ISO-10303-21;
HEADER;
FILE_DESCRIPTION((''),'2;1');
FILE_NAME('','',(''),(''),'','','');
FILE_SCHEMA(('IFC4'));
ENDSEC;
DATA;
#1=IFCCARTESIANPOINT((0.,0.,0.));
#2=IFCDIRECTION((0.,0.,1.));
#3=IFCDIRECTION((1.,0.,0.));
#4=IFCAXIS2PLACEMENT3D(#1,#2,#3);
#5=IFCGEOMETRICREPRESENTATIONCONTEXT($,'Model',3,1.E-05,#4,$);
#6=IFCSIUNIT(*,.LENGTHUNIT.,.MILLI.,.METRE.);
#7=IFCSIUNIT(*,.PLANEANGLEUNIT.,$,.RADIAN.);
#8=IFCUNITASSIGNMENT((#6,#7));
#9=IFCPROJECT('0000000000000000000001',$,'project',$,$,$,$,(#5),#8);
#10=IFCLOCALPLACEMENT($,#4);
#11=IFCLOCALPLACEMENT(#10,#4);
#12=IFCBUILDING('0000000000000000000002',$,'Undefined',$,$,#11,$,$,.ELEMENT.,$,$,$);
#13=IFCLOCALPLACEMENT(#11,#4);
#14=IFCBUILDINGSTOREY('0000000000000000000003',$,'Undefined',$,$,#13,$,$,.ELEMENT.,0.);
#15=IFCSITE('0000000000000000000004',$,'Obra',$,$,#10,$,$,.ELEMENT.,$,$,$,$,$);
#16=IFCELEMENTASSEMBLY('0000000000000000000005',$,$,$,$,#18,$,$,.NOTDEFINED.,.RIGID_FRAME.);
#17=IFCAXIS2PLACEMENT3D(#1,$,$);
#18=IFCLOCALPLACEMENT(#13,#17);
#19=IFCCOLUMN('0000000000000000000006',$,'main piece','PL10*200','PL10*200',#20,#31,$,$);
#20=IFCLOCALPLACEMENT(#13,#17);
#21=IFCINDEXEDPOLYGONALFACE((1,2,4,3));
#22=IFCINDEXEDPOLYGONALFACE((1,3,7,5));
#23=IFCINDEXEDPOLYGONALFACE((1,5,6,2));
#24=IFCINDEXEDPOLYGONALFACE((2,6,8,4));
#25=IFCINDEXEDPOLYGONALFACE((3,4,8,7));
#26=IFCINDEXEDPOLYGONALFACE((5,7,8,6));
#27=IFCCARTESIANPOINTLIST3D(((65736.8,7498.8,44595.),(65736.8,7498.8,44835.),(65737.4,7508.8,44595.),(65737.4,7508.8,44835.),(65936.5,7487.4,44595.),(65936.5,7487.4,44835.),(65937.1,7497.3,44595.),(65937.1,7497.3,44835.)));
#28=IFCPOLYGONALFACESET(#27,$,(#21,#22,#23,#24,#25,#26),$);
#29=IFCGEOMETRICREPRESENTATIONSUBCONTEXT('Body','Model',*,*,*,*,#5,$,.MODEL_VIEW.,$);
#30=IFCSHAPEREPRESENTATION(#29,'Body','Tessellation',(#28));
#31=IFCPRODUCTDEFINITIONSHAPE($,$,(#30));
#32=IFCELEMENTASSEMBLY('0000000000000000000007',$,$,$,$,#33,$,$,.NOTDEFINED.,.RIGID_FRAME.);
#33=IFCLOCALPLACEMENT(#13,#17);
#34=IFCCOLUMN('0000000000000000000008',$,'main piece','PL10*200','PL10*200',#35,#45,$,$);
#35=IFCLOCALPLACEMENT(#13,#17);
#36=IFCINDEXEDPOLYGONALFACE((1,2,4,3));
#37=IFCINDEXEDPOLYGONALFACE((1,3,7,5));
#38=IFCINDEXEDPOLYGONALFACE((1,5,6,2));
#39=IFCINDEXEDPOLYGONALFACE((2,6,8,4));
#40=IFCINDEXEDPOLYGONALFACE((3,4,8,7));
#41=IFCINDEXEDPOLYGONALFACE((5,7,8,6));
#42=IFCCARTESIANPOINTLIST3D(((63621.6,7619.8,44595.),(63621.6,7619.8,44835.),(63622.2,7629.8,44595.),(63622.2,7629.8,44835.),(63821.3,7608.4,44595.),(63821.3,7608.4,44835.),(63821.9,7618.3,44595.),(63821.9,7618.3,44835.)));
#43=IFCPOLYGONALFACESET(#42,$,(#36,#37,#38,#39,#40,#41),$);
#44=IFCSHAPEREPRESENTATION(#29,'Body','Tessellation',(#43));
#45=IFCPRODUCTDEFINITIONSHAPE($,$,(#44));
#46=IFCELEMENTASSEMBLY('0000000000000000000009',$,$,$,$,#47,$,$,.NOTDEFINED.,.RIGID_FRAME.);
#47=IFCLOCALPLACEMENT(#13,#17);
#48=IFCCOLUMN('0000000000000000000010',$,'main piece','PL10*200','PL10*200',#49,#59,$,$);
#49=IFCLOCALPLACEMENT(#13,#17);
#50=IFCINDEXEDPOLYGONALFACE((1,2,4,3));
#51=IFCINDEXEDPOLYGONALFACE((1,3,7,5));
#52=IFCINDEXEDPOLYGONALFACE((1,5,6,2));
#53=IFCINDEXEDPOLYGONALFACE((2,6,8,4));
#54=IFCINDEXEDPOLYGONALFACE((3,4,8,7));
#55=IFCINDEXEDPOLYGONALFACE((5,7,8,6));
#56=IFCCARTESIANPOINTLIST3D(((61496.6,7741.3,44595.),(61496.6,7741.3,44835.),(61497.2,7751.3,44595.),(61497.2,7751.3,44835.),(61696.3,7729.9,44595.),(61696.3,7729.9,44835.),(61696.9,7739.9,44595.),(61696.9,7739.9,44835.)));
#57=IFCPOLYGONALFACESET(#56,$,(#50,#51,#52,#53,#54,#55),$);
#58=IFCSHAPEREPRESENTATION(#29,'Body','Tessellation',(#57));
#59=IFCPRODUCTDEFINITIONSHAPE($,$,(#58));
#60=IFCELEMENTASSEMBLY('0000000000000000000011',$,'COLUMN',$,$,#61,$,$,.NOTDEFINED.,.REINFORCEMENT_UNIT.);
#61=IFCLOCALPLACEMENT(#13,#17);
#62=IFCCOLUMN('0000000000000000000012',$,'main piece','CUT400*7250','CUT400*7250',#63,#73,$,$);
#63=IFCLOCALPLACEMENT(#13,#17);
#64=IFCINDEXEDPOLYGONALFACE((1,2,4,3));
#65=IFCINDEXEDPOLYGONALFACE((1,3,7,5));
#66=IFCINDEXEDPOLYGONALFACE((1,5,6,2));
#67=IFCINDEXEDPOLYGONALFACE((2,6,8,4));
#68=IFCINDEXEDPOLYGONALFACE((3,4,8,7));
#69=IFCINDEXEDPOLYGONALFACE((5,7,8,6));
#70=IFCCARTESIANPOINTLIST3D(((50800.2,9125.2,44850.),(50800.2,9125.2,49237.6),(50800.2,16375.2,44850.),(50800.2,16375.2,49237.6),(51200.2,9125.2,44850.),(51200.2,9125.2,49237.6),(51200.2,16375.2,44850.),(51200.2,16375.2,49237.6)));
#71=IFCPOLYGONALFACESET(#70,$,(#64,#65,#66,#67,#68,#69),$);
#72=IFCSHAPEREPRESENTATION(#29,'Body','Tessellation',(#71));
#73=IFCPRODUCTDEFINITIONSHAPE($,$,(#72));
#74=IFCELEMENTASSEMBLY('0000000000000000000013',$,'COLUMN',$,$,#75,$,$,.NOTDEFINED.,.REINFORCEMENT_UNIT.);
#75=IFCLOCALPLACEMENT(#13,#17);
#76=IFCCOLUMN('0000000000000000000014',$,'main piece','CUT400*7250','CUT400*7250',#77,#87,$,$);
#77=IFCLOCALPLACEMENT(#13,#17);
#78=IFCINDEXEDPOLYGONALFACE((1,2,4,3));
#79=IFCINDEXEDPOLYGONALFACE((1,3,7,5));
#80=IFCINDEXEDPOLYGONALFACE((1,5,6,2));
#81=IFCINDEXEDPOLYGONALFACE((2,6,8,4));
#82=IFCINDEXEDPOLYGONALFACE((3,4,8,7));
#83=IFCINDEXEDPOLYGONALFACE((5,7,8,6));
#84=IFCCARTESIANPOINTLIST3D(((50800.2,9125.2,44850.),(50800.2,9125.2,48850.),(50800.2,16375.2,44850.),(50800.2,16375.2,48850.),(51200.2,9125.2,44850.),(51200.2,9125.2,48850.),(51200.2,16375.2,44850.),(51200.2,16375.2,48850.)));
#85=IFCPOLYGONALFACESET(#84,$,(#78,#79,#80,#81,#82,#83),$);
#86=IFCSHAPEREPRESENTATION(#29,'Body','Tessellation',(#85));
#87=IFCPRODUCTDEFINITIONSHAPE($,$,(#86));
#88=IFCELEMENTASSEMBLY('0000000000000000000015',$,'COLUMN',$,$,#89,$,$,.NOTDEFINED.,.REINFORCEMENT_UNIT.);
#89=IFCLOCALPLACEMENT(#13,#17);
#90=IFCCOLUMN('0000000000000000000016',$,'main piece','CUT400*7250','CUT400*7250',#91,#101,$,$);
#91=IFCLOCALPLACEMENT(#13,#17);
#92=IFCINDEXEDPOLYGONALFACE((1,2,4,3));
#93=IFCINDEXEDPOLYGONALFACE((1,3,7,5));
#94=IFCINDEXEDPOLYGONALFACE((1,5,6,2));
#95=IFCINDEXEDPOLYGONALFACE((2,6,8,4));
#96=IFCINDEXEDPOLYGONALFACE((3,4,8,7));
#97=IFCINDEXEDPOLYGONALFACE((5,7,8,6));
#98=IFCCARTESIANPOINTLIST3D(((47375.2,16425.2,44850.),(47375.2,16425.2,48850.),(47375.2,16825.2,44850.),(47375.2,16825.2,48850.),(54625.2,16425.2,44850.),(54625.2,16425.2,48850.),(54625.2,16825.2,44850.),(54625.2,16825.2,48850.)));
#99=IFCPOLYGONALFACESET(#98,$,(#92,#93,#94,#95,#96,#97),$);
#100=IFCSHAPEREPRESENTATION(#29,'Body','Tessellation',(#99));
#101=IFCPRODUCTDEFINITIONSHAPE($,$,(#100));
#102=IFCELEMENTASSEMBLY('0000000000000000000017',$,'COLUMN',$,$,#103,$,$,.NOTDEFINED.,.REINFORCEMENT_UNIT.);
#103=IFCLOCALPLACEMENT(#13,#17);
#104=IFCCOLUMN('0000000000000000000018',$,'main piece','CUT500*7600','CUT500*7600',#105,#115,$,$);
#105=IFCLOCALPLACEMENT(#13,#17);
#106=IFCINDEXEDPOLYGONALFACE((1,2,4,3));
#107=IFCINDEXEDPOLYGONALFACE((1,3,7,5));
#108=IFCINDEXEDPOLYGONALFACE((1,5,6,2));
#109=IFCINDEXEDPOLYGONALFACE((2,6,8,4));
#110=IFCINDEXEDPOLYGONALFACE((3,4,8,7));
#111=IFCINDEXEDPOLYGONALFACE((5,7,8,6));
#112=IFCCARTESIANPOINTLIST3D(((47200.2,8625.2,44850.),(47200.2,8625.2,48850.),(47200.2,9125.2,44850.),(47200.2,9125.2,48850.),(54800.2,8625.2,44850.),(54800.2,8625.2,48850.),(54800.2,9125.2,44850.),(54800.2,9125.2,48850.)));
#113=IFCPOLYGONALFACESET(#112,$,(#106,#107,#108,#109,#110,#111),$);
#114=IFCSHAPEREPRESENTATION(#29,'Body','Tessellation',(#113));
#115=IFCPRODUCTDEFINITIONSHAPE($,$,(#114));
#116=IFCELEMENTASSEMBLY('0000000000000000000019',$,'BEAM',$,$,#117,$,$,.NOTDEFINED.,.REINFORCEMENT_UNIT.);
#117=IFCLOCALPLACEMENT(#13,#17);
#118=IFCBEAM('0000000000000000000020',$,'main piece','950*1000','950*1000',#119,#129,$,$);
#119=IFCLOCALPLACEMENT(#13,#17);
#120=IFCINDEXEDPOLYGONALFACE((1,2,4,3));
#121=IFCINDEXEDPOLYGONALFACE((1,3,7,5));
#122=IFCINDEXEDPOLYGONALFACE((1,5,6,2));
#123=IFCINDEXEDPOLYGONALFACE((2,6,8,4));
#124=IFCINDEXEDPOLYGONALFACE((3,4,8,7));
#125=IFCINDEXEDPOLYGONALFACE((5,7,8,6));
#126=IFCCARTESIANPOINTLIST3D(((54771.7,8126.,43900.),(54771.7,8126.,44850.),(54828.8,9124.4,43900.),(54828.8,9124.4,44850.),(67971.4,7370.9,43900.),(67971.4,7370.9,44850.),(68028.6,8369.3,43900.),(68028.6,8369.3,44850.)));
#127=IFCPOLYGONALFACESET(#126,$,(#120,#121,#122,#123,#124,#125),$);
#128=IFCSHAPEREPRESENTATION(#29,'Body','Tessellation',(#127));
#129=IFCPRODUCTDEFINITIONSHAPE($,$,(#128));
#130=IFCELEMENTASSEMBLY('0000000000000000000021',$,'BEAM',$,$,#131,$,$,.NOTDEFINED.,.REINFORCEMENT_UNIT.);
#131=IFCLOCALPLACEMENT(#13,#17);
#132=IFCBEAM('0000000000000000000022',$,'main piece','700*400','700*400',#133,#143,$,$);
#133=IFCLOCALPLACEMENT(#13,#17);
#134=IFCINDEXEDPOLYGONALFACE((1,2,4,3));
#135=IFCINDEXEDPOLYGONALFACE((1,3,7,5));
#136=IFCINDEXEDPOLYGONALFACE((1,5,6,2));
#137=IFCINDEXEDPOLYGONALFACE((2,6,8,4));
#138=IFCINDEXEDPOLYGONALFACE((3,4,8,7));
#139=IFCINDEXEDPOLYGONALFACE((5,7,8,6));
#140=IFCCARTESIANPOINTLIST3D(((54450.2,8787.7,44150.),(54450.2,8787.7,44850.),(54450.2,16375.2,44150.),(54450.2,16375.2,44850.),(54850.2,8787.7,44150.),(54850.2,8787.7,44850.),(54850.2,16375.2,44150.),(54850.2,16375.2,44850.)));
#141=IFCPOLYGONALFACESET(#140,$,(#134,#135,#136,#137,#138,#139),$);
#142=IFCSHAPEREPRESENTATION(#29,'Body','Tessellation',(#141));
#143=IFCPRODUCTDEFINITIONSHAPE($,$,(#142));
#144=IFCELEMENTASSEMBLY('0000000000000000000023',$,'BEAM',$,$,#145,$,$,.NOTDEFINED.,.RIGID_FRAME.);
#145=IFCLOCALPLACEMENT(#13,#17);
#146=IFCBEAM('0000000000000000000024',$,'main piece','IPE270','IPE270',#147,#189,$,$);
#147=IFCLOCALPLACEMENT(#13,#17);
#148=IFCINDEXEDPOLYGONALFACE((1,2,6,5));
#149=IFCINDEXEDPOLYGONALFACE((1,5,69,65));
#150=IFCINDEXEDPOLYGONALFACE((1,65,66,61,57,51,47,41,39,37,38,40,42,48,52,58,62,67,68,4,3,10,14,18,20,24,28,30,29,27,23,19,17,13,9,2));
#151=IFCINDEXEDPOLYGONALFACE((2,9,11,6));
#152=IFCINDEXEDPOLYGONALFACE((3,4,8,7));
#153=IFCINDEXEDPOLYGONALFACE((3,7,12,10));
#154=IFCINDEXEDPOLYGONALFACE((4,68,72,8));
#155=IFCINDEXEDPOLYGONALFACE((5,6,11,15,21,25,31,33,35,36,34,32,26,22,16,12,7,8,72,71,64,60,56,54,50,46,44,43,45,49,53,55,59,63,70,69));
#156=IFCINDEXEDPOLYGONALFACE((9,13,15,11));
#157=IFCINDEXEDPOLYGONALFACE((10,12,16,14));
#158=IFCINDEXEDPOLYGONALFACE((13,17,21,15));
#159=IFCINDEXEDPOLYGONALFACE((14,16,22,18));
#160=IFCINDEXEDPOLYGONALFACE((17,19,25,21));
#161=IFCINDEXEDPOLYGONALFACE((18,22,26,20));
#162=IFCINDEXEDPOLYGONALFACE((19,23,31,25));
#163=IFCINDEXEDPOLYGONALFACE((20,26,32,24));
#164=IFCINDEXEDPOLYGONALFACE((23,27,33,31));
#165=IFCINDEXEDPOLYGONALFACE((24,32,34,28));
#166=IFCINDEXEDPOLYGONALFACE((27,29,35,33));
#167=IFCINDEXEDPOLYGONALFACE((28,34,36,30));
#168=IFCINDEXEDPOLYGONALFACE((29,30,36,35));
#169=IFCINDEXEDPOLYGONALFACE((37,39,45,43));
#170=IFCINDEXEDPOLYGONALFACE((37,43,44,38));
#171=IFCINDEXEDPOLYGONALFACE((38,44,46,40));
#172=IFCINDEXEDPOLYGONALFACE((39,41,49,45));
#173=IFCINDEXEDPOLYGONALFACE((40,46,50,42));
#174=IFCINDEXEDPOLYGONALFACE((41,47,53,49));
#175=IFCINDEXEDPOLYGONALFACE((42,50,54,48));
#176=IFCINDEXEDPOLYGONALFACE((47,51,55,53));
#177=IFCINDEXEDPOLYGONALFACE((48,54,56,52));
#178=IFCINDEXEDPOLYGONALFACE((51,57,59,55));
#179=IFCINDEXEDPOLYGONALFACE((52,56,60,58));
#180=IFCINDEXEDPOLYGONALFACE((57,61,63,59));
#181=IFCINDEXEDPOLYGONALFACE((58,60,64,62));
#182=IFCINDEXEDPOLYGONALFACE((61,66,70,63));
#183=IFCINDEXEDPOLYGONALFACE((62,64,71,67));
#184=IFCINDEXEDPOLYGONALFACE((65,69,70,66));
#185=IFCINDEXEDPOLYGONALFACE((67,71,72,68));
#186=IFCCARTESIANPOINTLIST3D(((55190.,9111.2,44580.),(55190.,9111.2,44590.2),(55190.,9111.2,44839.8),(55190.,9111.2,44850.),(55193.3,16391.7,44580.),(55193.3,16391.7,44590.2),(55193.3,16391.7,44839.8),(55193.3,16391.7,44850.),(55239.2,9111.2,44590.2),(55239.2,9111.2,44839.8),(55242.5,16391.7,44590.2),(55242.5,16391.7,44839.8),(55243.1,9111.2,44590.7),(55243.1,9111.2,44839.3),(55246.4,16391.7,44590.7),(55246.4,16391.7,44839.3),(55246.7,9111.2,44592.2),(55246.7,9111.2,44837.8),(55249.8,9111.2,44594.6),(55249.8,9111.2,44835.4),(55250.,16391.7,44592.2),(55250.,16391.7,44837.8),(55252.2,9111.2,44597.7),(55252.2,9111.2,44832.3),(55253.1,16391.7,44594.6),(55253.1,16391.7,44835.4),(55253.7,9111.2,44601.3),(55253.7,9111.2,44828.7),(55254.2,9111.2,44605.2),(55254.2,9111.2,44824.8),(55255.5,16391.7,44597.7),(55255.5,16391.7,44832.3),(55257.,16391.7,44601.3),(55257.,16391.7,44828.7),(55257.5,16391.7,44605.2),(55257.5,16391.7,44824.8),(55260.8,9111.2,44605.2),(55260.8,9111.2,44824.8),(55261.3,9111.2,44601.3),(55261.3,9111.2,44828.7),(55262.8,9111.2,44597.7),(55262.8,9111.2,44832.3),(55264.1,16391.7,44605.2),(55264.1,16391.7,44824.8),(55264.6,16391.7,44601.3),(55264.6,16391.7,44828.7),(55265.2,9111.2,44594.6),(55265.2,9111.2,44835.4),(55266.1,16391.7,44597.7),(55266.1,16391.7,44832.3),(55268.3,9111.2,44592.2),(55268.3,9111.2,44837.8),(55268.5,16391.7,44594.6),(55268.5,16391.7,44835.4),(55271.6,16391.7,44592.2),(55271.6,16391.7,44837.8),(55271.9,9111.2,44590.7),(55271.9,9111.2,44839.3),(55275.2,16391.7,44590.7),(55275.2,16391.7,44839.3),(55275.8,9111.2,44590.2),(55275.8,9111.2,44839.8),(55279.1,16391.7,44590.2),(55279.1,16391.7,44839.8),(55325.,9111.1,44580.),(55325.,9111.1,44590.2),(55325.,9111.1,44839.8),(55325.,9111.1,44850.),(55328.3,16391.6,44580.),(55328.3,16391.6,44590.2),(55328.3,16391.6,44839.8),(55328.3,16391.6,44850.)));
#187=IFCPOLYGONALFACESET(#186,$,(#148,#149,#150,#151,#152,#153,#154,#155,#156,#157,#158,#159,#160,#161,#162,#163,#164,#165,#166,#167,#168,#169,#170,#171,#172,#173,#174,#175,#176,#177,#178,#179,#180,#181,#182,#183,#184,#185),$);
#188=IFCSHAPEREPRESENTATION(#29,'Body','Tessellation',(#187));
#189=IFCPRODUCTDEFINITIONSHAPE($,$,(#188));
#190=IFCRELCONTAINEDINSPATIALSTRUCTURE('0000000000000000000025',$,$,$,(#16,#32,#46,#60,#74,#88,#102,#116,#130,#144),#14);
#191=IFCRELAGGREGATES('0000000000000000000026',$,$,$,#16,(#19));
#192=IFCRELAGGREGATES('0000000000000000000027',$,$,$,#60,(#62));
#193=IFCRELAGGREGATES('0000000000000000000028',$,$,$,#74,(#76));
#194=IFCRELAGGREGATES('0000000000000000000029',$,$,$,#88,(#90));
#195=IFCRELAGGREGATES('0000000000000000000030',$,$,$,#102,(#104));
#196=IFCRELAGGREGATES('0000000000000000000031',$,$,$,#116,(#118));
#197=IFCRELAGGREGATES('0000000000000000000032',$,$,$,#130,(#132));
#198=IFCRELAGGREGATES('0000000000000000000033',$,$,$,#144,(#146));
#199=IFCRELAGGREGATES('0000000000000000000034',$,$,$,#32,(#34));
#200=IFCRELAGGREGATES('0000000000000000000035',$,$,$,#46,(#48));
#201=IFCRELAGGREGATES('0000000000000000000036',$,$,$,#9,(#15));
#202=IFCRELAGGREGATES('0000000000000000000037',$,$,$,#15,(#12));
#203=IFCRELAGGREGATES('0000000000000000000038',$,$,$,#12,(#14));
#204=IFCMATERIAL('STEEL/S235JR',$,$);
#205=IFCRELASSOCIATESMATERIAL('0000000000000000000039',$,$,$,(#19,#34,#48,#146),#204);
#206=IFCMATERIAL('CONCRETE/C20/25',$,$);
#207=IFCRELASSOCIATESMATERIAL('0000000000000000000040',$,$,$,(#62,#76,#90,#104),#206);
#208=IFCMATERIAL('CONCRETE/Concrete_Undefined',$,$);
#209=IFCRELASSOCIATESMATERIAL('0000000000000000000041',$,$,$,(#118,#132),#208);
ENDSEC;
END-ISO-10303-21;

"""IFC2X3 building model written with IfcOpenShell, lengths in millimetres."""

from ifc_helpers import new_model, si_unit, frame, origin_with_axes, origin_2d_with_axis, place, context, subcontext, project, spatial, rectangle, i_section, extrude, material, element, aggregate, save


model = new_model("IFC2X3")

# Units and contexts
model_context = context("Model", 3, precision=1e-05, world=origin_with_axes())
body_context = subcontext(model_context, "Body", "Model", "MODEL_VIEW")
ifc_project = project(units=[si_unit("LENGTHUNIT", "METRE", prefix="MILLI"), si_unit("PLANEANGLEUNIT", "RADIAN")], contexts=[model_context])

# Site, building, storey
site_placement = place(None, origin_with_axes())
site = spatial("IfcSite", under=ifc_project, at=site_placement, Name="Obra", CompositionType="ELEMENT")
building_placement = place(site_placement, origin_with_axes())
building = spatial("IfcBuilding", under=site, at=building_placement, Name="Undefined", CompositionType="ELEMENT")
storey_placement = place(building_placement, origin_with_axes())
storey = spatial("IfcBuildingStorey", under=building, at=storey_placement, Name="Undefined", CompositionType="ELEMENT", Elevation=0.0)

# Element assemblies, columns
assembly_1_placement = place(storey_placement, origin_with_axes())
assembly_1 = element("IfcElementAssembly", 1, at=assembly_1_placement, inside=storey, AssemblyPlace="NOTDEFINED", PredefinedType="RIGID_FRAME")
ifc_material_1 = material(Name="STEEL/S235JR")
column_1_placement = place(assembly_1_placement, frame((65836.9, 7498.1, 44595.0), z_axis=(0.0, 0.0, 1.0), x_axis=(-0.998368, 0.05711, 0.0)))
column_1 = element("IfcColumn", 2, at=column_1_placement, material=ifc_material_1, Name="main piece", Description="PL10*200", ObjectType="PL10*200", context=body_context, shape_type="SweptSolid", body=[
    extrude(rectangle(XDim=10.0, YDim=200.0, at=origin_2d_with_axis()), frame((0.0, 0.0, 240.0), z_axis=(0.0, 0.0, -1.0), x_axis=(0.0, 1.0, 0.0)), (0.0, 0.0, 1.0), 240.0),
])
aggregate(assembly_1, [column_1])
assembly_2_placement = place(storey_placement, origin_with_axes())
assembly_2 = element("IfcElementAssembly", 3, at=assembly_2_placement, inside=storey, AssemblyPlace="NOTDEFINED", PredefinedType="RIGID_FRAME")
column_2_placement = place(assembly_2_placement, frame((63721.7, 7619.1, 44595.0), z_axis=(0.0, 0.0, 1.0), x_axis=(-0.998368, 0.05711, 0.0)))
column_2 = element("IfcColumn", 4, at=column_2_placement, material=ifc_material_1, Name="main piece", Description="PL10*200", ObjectType="PL10*200", context=body_context, shape_type="SweptSolid", body=[
    extrude(rectangle(XDim=10.0, YDim=200.0, at=origin_2d_with_axis()), frame((0.0, 0.0, 240.0), z_axis=(0.0, 0.0, -1.0), x_axis=(0.0, 1.0, 0.0)), (0.0, 0.0, 1.0), 240.0),
])
assembly_3_placement = place(storey_placement, origin_with_axes())
assembly_3 = element("IfcElementAssembly", 5, at=assembly_3_placement, inside=storey, AssemblyPlace="NOTDEFINED", PredefinedType="RIGID_FRAME")
column_3_placement = place(assembly_3_placement, frame((61596.7, 7740.6, 44595.0), z_axis=(0.0, 0.0, 1.0), x_axis=(-0.998368, 0.05711, 0.0)))
column_3 = element("IfcColumn", 6, at=column_3_placement, material=ifc_material_1, Name="main piece", Description="PL10*200", ObjectType="PL10*200", context=body_context, shape_type="SweptSolid", body=[
    extrude(rectangle(XDim=10.0, YDim=200.0, at=origin_2d_with_axis()), frame((0.0, 0.0, 240.0), z_axis=(0.0, 0.0, -1.0), x_axis=(0.0, 1.0, 0.0)), (0.0, 0.0, 1.0), 240.0),
])
assembly_4_placement = place(storey_placement, origin_with_axes())
assembly_4 = element("IfcElementAssembly", 7, at=assembly_4_placement, inside=storey, Name="COLUMN", AssemblyPlace="NOTDEFINED", PredefinedType="REINFORCEMENT_UNIT")
ifc_material_2 = material(Name="CONCRETE/C20/25")
column_4_placement = place(assembly_4_placement, frame((51000.2, 12750.2, 44850.0), z_axis=(0.0, 0.0, 1.0), x_axis=(0.0, -1.0, 0.0)))
column_4 = element("IfcColumn", 8, at=column_4_placement, material=ifc_material_2, Name="main piece", Description="CUT400*7250", ObjectType="CUT400*7250", context=body_context, shape_type="SweptSolid", body=[
    extrude(rectangle(XDim=400.0, YDim=7250.0, at=origin_2d_with_axis()), frame((0.0, 0.0, 4387.6), z_axis=(0.0, 0.0, -1.0), x_axis=(0.0, 1.0, 0.0)), (0.0, 0.0, 1.0), 4387.6),
])
aggregate(assembly_4, [column_4])
assembly_5_placement = place(storey_placement, origin_with_axes())
assembly_5 = element("IfcElementAssembly", 9, at=assembly_5_placement, inside=storey, Name="COLUMN", AssemblyPlace="NOTDEFINED", PredefinedType="REINFORCEMENT_UNIT")
column_5_placement = place(assembly_5_placement, frame((51000.2, 12750.2, 44850.0), z_axis=(0.0, 0.0, 1.0), x_axis=(0.0, -1.0, 0.0)))
column_5 = element("IfcColumn", 10, at=column_5_placement, material=ifc_material_2, Name="main piece", Description="CUT400*7250", ObjectType="CUT400*7250", context=body_context, shape_type="SweptSolid", body=[
    extrude(rectangle(XDim=400.0, YDim=7250.0, at=origin_2d_with_axis()), frame((0.0, 0.0, 4000.0), z_axis=(0.0, 0.0, -1.0), x_axis=(0.0, 1.0, 0.0)), (0.0, 0.0, 1.0), 4000.0),
])
aggregate(assembly_5, [column_5])
assembly_6_placement = place(storey_placement, origin_with_axes())
assembly_6 = element("IfcElementAssembly", 11, at=assembly_6_placement, inside=storey, Name="COLUMN", AssemblyPlace="NOTDEFINED", PredefinedType="REINFORCEMENT_UNIT")
column_6_placement = place(assembly_6_placement, frame((51000.2, 16625.2, 44850.0), z_axis=(0.0, 0.0, 1.0), x_axis=(-1.0, 0.0, 0.0)))
column_6 = element("IfcColumn", 12, at=column_6_placement, material=ifc_material_2, Name="main piece", Description="CUT400*7250", ObjectType="CUT400*7250", context=body_context, shape_type="SweptSolid", body=[
    extrude(rectangle(XDim=400.0, YDim=7250.0, at=origin_2d_with_axis()), frame((0.0, 0.0, 4000.0), z_axis=(0.0, 0.0, -1.0), x_axis=(0.0, 1.0, 0.0)), (0.0, 0.0, 1.0), 4000.0),
])
aggregate(assembly_6, [column_6])
assembly_7_placement = place(storey_placement, origin_with_axes())
assembly_7 = element("IfcElementAssembly", 13, at=assembly_7_placement, inside=storey, Name="COLUMN", AssemblyPlace="NOTDEFINED", PredefinedType="REINFORCEMENT_UNIT")
column_7_placement = place(assembly_7_placement, frame((51000.2, 8875.2, 44850.0), z_axis=(0.0, 0.0, 1.0), x_axis=(-1.0, 0.0, 0.0)))
column_7 = element("IfcColumn", 14, at=column_7_placement, material=ifc_material_2, Name="main piece", Description="CUT500*7600", ObjectType="CUT500*7600", context=body_context, shape_type="SweptSolid", body=[
    extrude(rectangle(XDim=500.0, YDim=7600.0, at=origin_2d_with_axis()), frame((0.0, 0.0, 4000.0), z_axis=(0.0, 0.0, -1.0), x_axis=(0.0, 1.0, 0.0)), (0.0, 0.0, 1.0), 4000.0),
])
aggregate(assembly_7, [column_7])

# Element assemblies, beams
assembly_8_placement = place(storey_placement, origin_with_axes())
assembly_8 = element("IfcElementAssembly", 15, at=assembly_8_placement, inside=storey, Name="BEAM", AssemblyPlace="NOTDEFINED", PredefinedType="REINFORCEMENT_UNIT")
ifc_material_3 = material(Name="CONCRETE/Concrete_Undefined")
beam_1_placement = place(assembly_8_placement, frame((54800.2, 8625.2, 44375.0), z_axis=(0.0, 0.0, 1.0), x_axis=(0.998368, -0.05711, 0.0)))
beam_1 = element("IfcBeam", 16, at=beam_1_placement, material=ifc_material_3, Name="main piece", Description="950*1000", ObjectType="950*1000", context=body_context, shape_type="SweptSolid", body=[
    extrude(rectangle(XDim=1000.0, YDim=950.0, at=origin_2d_with_axis()), frame((13221.4, 0.0, 0.0), z_axis=(-1.0, 0.0, 0.0), x_axis=(0.0, -1.0, 0.0)), (0.0, 0.0, 1.0), 13221.4),
])
aggregate(assembly_8, [beam_1])
assembly_9_placement = place(storey_placement, origin_with_axes())
assembly_9 = element("IfcElementAssembly", 17, at=assembly_9_placement, inside=storey, Name="BEAM", AssemblyPlace="NOTDEFINED", PredefinedType="REINFORCEMENT_UNIT")
beam_2_placement = place(assembly_9_placement, frame((54650.2, 8787.7, 44500.0), z_axis=(0.0, 0.0, 1.0), x_axis=(-0.000002, 1.0, 0.0)))
beam_2 = element("IfcBeam", 18, at=beam_2_placement, material=ifc_material_3, Name="main piece", Description="700*400", ObjectType="700*400", context=body_context, shape_type="SweptSolid", body=[
    extrude(rectangle(XDim=400.0, YDim=700.0, at=origin_2d_with_axis()), frame((7587.4, 0.0, 0.0), z_axis=(-1.0, 0.0, 0.0), x_axis=(0.0, -1.0, 0.0)), (0.0, 0.0, 1.0), 7587.4),
])
aggregate(assembly_9, [beam_2])
assembly_10_placement = place(storey_placement, origin_with_axes())
assembly_10 = element("IfcElementAssembly", 19, at=assembly_10_placement, inside=storey, Name="BEAM", AssemblyPlace="NOTDEFINED", PredefinedType="RIGID_FRAME")
beam_3_placement = place(assembly_10_placement, frame((55257.5, 9111.2, 44715.0), z_axis=(0.0, 0.0, 1.0), x_axis=(0.000453, 1.0, 0.0)))
beam_3 = element("IfcBeam", 20, at=beam_3_placement, material=ifc_material_1, Name="main piece", Description="IPE270", ObjectType="IPE270", context=body_context, shape_type="SweptSolid", body=[
    extrude(i_section(OverallWidth=135.0, OverallDepth=270.0, WebThickness=6.6, FlangeThickness=10.2, FilletRadius=15.0, at=origin_2d_with_axis()), frame((7280.5, 0.0, 0.0), z_axis=(-1.0, 0.0, 0.0), x_axis=(0.0, -1.0, 0.0)), (0.0, 0.0, 1.0), 7280.5),
])
aggregate(assembly_10, [beam_3])

aggregate(assembly_2, [column_2])
aggregate(assembly_3, [column_3])

save(model, "model.ifc")
